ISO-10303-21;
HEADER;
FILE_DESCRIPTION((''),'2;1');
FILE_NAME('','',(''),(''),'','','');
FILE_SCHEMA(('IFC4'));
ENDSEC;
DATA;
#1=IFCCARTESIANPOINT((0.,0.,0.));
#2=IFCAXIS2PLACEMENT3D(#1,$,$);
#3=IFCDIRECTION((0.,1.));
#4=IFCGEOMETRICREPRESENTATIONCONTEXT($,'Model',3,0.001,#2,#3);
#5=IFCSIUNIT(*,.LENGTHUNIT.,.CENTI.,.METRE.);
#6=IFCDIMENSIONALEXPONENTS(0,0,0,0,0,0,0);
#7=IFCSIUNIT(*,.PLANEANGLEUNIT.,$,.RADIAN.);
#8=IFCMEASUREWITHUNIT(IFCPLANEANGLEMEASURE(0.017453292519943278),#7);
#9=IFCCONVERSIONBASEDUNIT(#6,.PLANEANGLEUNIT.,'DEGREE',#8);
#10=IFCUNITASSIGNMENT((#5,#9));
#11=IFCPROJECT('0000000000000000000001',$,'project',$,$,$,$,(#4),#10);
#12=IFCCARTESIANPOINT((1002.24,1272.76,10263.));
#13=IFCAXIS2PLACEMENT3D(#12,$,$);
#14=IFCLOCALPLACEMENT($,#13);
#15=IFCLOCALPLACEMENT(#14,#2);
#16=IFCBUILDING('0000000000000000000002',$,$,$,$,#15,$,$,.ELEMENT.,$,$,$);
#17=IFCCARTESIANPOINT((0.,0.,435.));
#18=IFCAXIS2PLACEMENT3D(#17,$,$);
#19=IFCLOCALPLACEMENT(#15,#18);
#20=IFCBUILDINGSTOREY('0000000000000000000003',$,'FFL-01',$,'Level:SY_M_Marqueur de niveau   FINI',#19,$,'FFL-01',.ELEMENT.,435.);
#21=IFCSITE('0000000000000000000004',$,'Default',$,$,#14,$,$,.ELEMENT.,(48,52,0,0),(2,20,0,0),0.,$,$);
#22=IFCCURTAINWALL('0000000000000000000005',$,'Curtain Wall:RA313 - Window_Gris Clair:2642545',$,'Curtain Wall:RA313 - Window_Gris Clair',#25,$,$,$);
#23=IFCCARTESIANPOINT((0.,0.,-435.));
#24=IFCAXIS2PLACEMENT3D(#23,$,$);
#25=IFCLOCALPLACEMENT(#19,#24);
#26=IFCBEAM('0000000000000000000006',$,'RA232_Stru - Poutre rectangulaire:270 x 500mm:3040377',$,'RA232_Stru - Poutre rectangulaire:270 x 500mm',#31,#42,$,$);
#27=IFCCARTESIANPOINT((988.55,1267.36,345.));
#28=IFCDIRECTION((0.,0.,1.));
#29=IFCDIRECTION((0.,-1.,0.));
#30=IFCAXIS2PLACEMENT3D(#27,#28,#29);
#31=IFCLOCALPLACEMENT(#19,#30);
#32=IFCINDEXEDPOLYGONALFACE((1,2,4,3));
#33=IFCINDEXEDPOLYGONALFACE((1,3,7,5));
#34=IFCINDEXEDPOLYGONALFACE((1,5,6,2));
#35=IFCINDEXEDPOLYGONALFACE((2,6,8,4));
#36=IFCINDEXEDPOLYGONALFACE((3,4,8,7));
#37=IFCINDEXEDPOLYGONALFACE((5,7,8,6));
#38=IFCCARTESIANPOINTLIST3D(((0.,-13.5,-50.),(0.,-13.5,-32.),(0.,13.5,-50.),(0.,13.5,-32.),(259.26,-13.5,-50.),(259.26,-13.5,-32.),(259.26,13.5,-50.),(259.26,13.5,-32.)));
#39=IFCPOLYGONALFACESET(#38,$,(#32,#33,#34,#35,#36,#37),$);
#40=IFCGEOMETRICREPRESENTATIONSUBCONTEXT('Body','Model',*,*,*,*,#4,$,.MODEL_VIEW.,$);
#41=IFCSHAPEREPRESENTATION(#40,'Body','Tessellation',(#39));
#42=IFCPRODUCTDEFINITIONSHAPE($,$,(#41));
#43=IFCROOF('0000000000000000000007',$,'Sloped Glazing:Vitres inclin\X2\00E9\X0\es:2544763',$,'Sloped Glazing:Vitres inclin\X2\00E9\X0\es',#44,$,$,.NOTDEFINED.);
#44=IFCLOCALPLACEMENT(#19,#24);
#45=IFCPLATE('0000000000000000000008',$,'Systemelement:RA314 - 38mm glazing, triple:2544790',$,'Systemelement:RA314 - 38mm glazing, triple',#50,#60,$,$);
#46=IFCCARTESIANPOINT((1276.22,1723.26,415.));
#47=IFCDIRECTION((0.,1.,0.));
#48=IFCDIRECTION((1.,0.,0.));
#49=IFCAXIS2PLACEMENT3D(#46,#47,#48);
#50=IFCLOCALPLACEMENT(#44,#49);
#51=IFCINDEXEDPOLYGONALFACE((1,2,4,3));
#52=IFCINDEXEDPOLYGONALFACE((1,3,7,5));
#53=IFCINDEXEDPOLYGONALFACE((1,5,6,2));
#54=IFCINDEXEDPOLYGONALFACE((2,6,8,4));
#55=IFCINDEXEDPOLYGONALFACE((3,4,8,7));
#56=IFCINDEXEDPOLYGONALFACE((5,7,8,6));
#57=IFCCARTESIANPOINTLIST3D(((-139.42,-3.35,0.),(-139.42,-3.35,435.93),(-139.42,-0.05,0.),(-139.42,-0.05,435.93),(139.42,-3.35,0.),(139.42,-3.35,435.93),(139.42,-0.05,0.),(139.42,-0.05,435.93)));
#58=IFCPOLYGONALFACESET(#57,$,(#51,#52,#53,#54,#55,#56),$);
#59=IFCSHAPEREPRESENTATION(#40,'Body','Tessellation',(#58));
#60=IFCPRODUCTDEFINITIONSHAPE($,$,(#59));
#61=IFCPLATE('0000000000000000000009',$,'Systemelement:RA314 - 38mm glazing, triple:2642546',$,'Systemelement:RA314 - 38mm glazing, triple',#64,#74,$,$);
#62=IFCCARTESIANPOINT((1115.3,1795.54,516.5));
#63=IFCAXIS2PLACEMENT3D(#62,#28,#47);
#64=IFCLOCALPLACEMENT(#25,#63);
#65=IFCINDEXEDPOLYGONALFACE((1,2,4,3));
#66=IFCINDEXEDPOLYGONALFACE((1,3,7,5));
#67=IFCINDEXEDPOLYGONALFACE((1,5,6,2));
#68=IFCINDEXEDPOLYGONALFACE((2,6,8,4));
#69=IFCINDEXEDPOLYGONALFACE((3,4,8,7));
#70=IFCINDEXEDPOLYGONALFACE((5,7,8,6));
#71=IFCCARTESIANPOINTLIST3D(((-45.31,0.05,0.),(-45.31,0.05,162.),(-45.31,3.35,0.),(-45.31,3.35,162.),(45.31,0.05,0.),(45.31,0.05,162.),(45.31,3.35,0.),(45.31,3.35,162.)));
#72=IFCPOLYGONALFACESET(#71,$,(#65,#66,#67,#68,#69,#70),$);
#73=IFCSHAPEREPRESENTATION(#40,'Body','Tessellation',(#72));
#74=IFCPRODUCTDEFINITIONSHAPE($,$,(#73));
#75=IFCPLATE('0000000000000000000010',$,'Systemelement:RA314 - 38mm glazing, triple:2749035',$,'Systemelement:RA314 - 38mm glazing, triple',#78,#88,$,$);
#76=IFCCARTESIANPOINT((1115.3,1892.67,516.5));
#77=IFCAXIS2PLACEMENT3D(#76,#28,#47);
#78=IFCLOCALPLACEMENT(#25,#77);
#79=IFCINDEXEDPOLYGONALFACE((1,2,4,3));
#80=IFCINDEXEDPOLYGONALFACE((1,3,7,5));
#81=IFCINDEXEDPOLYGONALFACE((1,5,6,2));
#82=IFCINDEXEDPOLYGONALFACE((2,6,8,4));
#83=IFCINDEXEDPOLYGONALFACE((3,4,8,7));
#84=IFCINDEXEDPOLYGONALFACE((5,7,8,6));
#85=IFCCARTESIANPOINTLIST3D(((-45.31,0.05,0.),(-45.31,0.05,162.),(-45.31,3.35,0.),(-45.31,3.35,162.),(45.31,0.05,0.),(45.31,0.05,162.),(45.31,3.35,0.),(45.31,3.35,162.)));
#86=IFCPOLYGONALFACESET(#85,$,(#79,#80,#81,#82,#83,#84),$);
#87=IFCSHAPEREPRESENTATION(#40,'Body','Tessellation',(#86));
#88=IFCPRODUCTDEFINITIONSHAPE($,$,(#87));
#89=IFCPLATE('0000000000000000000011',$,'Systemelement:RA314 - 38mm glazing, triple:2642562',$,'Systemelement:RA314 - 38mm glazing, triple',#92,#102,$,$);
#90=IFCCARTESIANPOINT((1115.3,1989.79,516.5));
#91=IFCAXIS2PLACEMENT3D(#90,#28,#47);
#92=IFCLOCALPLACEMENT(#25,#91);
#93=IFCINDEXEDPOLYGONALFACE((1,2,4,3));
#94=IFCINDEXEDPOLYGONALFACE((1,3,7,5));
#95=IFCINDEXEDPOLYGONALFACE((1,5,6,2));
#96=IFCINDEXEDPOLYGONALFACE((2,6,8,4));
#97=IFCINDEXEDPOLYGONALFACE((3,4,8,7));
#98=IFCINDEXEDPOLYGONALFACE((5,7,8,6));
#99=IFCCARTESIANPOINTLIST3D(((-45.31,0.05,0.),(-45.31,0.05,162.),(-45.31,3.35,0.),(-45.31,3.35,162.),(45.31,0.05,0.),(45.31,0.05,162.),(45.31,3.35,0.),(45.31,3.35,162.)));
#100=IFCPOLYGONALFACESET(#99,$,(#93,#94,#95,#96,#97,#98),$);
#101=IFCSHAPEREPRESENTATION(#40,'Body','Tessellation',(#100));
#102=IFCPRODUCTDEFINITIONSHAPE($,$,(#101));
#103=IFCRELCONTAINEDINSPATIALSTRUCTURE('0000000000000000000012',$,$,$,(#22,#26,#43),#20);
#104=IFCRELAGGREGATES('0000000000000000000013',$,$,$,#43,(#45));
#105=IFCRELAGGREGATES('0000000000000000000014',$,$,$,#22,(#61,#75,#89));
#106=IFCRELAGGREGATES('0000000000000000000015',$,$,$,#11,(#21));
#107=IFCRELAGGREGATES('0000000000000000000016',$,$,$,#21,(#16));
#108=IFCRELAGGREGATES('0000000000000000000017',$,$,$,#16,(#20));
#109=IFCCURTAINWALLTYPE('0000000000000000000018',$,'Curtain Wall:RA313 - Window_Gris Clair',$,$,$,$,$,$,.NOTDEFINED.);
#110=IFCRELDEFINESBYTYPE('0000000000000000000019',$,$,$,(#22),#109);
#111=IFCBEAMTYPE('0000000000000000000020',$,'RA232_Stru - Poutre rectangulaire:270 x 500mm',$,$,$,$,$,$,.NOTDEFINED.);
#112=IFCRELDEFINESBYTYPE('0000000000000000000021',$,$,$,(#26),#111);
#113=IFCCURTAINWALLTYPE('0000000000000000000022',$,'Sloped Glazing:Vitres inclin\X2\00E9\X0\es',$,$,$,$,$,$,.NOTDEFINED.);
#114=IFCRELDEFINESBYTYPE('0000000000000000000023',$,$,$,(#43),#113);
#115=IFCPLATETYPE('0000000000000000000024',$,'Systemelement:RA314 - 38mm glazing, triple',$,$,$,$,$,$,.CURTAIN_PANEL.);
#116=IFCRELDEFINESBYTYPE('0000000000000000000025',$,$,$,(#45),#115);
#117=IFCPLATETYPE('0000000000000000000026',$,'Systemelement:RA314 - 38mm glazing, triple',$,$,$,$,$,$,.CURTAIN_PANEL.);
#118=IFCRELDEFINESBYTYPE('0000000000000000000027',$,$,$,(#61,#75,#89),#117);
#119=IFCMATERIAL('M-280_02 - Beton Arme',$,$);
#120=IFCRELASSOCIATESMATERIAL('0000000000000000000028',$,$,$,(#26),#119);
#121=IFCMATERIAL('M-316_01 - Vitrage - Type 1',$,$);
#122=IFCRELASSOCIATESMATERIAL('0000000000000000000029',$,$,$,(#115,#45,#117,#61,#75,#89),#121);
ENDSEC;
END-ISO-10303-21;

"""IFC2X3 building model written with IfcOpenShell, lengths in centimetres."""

from ifc_helpers import new_model, entity, si_unit, converted_unit, direction, frame, origin, origin_2d_with_axis, place, context, subcontext, project, spatial, rectangle, extrude, source, transform, mapped, material, type_object, type_shapes, element, aggregate, save


model = new_model("IFC2X3")

# Units and contexts
model_context = context("Model", 3, precision=0.001, world=origin(), true_north=direction((0.0, 1.0)))
body_context = subcontext(model_context, "Body", "Model", "MODEL_VIEW")
ifc_project = project(units=[si_unit("LENGTHUNIT", "METRE", prefix="CENTI"), converted_unit("PLANEANGLEUNIT", "DEGREE", entity("IfcPlaneAngleMeasure", 0.017453292519943278), si_unit("PLANEANGLEUNIT", "RADIAN"), dimensions=[0, 0, 0, 0, 0, 0, 0])], contexts=[model_context])

# Site, building, storey
site_placement = place(None, frame((1002.24, 1272.76, 10263.0)))
site = spatial("IfcSite", under=ifc_project, at=site_placement, Name="Default", CompositionType="ELEMENT", RefLatitude=(48, 52, 0, 0), RefLongitude=(2, 20, 0, 0), RefElevation=0.0)
building_placement = place(site_placement, origin())
building = spatial("IfcBuilding", under=site, at=building_placement, CompositionType="ELEMENT")
storey_placement = place(building_placement, frame((0.0, 0.0, 435.0)))
storey = spatial("IfcBuildingStorey", under=building, at=storey_placement, Name="FFL-01", ObjectType="Level:SY_M_Marqueur de niveau   FINI", LongName="FFL-01", CompositionType="ELEMENT", Elevation=435.0)

# Curtain wall
curtain_wall_type_1 = type_object("IfcCurtainWallType", Name="Curtain Wall:RA313 - Window_Gris Clair", PredefinedType="NOTDEFINED")
curtain_wall_1_placement = place(storey_placement, frame((0.0, 0.0, -435.0)))
curtain_wall_1 = element("IfcCurtainWall", 1, at=curtain_wall_1_placement, inside=storey, type_object=curtain_wall_type_1, Name="Curtain Wall:RA313 - Window_Gris Clair:2642545", ObjectType="Curtain Wall:RA313 - Window_Gris Clair")

# Beam
ifc_material_1 = material(Name="M-280_02 - Beton Arme")
beam_type = type_object("IfcBeamType", Name="RA232_Stru - Poutre rectangulaire:270 x 500mm", PredefinedType="NOTDEFINED")
beam_placement = place(storey_placement, frame((988.55, 1267.36, 345.0), z_axis=(0.0, 0.0, 1.0), x_axis=(0.0, -1.0, 0.0)))
element("IfcBeam", 2, at=beam_placement, inside=storey, type_object=beam_type, material=ifc_material_1, Name="RA232_Stru - Poutre rectangulaire:270 x 500mm:3040377", ObjectType="RA232_Stru - Poutre rectangulaire:270 x 500mm", context=body_context, shape_type="SweptSolid", body=[
    extrude(rectangle(XDim=18.0, YDim=27.0, at=origin_2d_with_axis()), frame((0.0, 0.0, -41.0), z_axis=(1.0, 0.0, 0.0), x_axis=(0.0, 0.0, -1.0)), (0.0, 0.0, 1.0), 259.26),
])

# Roof, plate
curtain_wall_type_2 = type_object("IfcCurtainWallType", Name="Sloped Glazing:Vitres inclinées", PredefinedType="NOTDEFINED")
roof_placement = place(storey_placement, frame((0.0, 0.0, -435.0)))
roof = element("IfcRoof", 3, at=roof_placement, inside=storey, type_object=curtain_wall_type_2, Name="Sloped Glazing:Vitres inclinées:2544763", ObjectType="Sloped Glazing:Vitres inclinées", ShapeType="NOTDEFINED")
ifc_material_2 = material(Name="M-316_01 - Vitrage - Type 1")
plate_type_1 = type_object("IfcPlateType", Name="Systemelement:RA314 - 38mm glazing, triple", PredefinedType="CURTAIN_PANEL", material=ifc_material_2)
shared_shape_1 = source(origin(), body_context, "Body", "SweptSolid", [
    extrude(rectangle(XDim=3.3, YDim=278.84, at=origin_2d_with_axis()), frame((0.0, -1.7, 0.0), z_axis=(0.0, 0.0, 1.0), x_axis=(0.0, 1.0, 0.0)), (0.0, 0.0, 1.0), 435.93),
])
type_shapes(plate_type_1, [shared_shape_1])
plate_1_placement = place(roof_placement, frame((1276.22, 1723.26, 415.0), z_axis=(0.0, 1.0, 0.0), x_axis=(1.0, 0.0, 0.0)))
plate_1 = element("IfcPlate", 4, at=plate_1_placement, type_object=plate_type_1, material=ifc_material_2, Name="Systemelement:RA314 - 38mm glazing, triple:2544790", ObjectType="Systemelement:RA314 - 38mm glazing, triple", context=body_context, shape_type="MappedRepresentation", body=[
    mapped(shared_shape_1, transform((0.0, 0.0, 0.0), scale=1.0)),
])
aggregate(roof, [plate_1])

# Plates
plate_type_2 = type_object("IfcPlateType", Name="Systemelement:RA314 - 38mm glazing, triple", PredefinedType="CURTAIN_PANEL", material=ifc_material_2)
shared_shape_2 = source(origin(), body_context, "Body", "SweptSolid", [
    extrude(rectangle(XDim=3.3, YDim=90.63, at=origin_2d_with_axis()), frame((0.0, 1.7, 0.0), z_axis=(0.0, 0.0, 1.0), x_axis=(0.0, 1.0, 0.0)), (0.0, 0.0, 1.0), 162.0),
])
type_shapes(plate_type_2, [shared_shape_2])
plate_2_placement = place(curtain_wall_1_placement, frame((1115.3, 1795.54, 516.5), z_axis=(0.0, 0.0, 1.0), x_axis=(0.0, 1.0, 0.0)))
plate_2 = element("IfcPlate", 5, at=plate_2_placement, type_object=plate_type_2, material=ifc_material_2, Name="Systemelement:RA314 - 38mm glazing, triple:2642546", ObjectType="Systemelement:RA314 - 38mm glazing, triple", context=body_context, shape_type="MappedRepresentation", body=[
    mapped(shared_shape_2, transform((0.0, 0.0, 0.0), scale=1.0)),
])
plate_3_placement = place(curtain_wall_1_placement, frame((1115.3, 1892.67, 516.5), z_axis=(0.0, 0.0, 1.0), x_axis=(0.0, 1.0, 0.0)))
plate_3 = element("IfcPlate", 6, at=plate_3_placement, type_object=plate_type_2, material=ifc_material_2, Name="Systemelement:RA314 - 38mm glazing, triple:2749035", ObjectType="Systemelement:RA314 - 38mm glazing, triple", context=body_context, shape_type="MappedRepresentation", body=[
    mapped(shared_shape_2, transform((0.0, 0.0, 0.0), scale=1.0)),
])
plate_4_placement = place(curtain_wall_1_placement, frame((1115.3, 1989.79, 516.5), z_axis=(0.0, 0.0, 1.0), x_axis=(0.0, 1.0, 0.0)))
plate_4 = element("IfcPlate", 7, at=plate_4_placement, type_object=plate_type_2, material=ifc_material_2, Name="Systemelement:RA314 - 38mm glazing, triple:2642562", ObjectType="Systemelement:RA314 - 38mm glazing, triple", context=body_context, shape_type="MappedRepresentation", body=[
    mapped(shared_shape_2, transform((0.0, 0.0, 0.0), scale=1.0)),
])
aggregate(curtain_wall_1, [plate_2, plate_3, plate_4])

save(model, "model.ifc")
